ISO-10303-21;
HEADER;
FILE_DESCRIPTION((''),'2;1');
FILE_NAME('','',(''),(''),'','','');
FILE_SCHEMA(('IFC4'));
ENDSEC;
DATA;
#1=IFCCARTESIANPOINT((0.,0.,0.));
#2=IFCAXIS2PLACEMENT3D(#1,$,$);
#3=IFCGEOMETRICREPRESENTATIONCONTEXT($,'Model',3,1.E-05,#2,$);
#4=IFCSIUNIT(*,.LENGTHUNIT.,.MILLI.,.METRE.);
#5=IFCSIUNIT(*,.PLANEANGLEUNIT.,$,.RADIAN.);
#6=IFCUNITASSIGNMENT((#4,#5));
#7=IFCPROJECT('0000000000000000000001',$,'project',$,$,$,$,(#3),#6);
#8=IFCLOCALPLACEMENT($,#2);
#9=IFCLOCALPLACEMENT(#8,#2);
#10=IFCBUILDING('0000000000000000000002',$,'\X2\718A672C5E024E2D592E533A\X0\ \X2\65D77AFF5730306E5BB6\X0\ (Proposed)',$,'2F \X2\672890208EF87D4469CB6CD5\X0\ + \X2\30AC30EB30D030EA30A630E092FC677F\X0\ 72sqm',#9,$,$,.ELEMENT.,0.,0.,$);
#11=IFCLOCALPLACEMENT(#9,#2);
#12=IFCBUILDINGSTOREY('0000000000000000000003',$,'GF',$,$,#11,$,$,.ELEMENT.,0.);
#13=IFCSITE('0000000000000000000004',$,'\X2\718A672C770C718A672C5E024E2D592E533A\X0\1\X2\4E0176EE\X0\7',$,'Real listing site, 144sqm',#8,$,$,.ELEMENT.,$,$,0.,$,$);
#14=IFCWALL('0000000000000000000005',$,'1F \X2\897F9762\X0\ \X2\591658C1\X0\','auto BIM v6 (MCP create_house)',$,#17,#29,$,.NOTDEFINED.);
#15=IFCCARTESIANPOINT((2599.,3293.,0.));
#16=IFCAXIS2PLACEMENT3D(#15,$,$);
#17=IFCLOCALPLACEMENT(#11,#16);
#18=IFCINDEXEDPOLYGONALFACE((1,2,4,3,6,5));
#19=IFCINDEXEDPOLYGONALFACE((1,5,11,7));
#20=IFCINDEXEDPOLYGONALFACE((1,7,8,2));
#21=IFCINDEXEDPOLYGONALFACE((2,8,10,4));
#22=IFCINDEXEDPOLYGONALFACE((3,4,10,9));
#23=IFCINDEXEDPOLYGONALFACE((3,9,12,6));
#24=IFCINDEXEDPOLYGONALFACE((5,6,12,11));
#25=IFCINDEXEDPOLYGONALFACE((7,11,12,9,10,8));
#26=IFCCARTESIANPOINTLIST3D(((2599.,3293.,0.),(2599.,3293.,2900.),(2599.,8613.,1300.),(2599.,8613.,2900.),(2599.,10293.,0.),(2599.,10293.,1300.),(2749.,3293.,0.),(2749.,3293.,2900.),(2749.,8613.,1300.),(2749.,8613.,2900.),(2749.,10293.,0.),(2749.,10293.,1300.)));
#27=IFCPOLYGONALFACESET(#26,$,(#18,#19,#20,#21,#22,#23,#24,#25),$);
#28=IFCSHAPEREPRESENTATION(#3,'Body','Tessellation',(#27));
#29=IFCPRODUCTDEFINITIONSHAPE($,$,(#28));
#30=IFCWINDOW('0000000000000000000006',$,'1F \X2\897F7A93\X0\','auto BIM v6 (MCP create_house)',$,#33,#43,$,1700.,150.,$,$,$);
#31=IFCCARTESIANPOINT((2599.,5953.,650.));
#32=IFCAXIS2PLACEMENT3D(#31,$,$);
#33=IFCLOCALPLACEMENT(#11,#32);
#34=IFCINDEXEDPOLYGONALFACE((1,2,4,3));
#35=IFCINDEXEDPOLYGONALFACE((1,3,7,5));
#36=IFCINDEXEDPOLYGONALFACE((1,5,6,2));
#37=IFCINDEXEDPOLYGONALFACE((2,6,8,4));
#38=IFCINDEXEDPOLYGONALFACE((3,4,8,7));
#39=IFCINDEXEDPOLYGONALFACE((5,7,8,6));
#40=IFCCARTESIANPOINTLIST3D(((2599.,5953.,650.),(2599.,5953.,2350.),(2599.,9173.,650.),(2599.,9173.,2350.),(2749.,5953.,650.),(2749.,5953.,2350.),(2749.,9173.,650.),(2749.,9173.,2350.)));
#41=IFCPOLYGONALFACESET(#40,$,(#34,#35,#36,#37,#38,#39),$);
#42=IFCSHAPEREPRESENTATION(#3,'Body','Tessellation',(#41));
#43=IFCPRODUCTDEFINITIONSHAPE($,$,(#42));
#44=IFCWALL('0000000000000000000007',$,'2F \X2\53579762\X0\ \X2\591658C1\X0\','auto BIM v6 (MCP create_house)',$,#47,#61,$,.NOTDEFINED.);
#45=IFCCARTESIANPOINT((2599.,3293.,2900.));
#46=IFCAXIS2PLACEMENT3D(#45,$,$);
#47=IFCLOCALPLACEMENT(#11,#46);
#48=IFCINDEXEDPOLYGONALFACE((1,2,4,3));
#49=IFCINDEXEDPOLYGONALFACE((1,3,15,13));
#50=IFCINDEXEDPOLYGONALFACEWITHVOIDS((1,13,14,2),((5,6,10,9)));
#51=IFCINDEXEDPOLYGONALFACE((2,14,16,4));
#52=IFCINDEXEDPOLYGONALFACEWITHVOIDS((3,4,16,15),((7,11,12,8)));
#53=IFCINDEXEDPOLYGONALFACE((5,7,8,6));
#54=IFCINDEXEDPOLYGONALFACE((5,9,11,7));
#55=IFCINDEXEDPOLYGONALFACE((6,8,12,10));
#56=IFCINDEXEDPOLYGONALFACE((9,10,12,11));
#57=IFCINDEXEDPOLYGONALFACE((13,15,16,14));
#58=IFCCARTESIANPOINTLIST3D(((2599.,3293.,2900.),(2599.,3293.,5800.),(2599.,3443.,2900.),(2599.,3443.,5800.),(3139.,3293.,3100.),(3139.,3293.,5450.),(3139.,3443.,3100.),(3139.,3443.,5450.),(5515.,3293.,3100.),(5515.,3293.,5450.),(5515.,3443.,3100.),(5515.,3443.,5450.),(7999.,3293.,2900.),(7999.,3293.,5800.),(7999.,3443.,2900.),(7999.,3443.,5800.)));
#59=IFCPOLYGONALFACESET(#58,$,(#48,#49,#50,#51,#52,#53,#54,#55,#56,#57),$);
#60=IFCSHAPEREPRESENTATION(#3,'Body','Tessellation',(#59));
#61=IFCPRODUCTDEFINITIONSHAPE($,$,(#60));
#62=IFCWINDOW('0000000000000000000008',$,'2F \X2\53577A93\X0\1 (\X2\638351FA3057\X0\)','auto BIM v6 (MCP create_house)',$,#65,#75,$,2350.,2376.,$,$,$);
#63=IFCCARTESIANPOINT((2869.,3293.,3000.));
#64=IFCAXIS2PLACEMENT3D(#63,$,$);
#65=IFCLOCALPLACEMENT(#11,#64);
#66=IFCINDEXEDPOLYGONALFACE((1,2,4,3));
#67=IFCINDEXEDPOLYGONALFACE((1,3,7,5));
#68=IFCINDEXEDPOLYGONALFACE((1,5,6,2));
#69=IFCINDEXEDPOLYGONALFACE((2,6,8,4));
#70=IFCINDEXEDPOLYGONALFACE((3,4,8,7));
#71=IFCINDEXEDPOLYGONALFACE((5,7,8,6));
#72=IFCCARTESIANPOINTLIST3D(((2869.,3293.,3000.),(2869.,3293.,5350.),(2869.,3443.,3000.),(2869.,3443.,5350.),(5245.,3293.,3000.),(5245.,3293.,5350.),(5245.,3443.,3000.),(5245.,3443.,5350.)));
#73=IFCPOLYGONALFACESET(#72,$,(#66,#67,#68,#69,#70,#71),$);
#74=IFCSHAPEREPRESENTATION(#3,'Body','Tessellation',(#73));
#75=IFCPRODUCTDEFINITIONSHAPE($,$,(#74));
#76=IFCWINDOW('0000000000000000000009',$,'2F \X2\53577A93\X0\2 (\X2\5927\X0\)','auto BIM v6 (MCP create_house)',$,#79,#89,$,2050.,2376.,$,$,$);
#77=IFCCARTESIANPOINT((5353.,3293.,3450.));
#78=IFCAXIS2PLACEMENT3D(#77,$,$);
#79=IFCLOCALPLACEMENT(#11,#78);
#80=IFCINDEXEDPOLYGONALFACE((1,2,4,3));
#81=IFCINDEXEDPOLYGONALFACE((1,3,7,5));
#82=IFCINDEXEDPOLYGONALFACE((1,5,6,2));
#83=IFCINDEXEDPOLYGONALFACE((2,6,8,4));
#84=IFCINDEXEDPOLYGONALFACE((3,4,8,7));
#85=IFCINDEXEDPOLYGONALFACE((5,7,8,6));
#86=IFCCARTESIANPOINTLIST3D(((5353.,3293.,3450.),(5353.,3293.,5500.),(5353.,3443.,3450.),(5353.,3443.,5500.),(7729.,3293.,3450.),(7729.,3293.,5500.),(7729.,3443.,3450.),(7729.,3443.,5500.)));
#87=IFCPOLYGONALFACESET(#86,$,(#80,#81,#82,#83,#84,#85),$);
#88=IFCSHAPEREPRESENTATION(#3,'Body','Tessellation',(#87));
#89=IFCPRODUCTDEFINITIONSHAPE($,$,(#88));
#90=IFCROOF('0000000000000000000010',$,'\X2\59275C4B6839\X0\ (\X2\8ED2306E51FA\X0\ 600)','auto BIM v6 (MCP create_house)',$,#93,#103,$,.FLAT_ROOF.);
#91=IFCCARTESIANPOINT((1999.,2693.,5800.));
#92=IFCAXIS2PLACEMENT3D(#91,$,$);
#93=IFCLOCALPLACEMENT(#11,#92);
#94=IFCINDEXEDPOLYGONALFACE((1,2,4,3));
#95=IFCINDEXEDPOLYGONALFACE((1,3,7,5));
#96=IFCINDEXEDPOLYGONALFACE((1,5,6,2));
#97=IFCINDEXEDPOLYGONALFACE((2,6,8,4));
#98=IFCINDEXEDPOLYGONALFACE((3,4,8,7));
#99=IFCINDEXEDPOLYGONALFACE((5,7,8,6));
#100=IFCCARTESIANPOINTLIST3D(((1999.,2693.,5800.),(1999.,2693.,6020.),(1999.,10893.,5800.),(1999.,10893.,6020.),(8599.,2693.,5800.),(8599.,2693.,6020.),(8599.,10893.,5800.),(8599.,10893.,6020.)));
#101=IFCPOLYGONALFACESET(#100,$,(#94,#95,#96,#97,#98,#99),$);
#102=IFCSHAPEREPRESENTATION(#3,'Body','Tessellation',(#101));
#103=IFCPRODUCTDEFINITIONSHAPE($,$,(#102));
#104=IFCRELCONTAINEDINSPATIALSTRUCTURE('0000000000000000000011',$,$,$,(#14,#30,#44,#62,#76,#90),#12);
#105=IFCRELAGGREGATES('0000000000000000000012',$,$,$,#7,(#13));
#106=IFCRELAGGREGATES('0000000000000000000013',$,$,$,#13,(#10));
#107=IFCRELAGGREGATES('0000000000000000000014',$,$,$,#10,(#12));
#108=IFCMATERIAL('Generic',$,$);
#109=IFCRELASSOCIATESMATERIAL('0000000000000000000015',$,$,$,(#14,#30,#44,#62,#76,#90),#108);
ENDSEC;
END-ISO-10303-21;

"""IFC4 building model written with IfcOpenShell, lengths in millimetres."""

from ifc_helpers import new_model, si_unit, frame, frame_2d, origin, place, context, project, spatial, rectangle, extrude, material, element, fill, save


model = new_model("IFC4")

# Units and contexts
model_context = context("Model", 3, precision=1e-05, world=origin())
ifc_project = project(units=[si_unit("LENGTHUNIT", "METRE", prefix="MILLI"), si_unit("PLANEANGLEUNIT", "RADIAN")], contexts=[model_context])

# Site, building, storey
site_placement = place(None, origin())
site = spatial("IfcSite", under=ifc_project, at=site_placement, Name="熊本県熊本市中央区1丁目7", ObjectType="Real listing site, 144sqm", CompositionType="ELEMENT", RefElevation=0.0)
building_placement = place(site_placement, origin())
building = spatial("IfcBuilding", under=site, at=building_placement, Name="熊本市中央区 旗竿地の家 (Proposed)", ObjectType="2F 木造軸組構法 + ガルバリウム鋼板 72sqm", CompositionType="ELEMENT", ElevationOfRefHeight=0.0, ElevationOfTerrain=0.0)
storey_placement = place(building_placement, origin())
storey = spatial("IfcBuildingStorey", under=building, at=storey_placement, Name="GF", CompositionType="ELEMENT", Elevation=0.0)

# Shared definitions
ifc_material = material(Name="Generic")

# Wall, opening, window
wall_1_placement = place(storey_placement, frame((2599.0, 3293.0, 0.0)))
wall_1 = element("IfcWall", 1, at=wall_1_placement, inside=storey, material=ifc_material, Name="1F 西面 外壁", Description="auto BIM v6 (MCP create_house)", PredefinedType="NOTDEFINED", context=model_context, shape_type="SweptSolid", body=[
    extrude(rectangle(XDim=150.0, YDim=7000.0, at=frame_2d((75.0, 3500.0))), frame((2599.0, 3293.0, 0.0)), (0.0, 0.0, 1.0), 2900.0),
])
opening_1_placement = place(storey_placement, frame((2599.0, 5953.0, 650.0)))
opening_1 = element("IfcOpeningElement", 2, at=opening_1_placement, cuts=wall_1, PredefinedType="NOTDEFINED", context=model_context, shape_type="SweptSolid", body=[
    extrude(rectangle(XDim=150.0, YDim=3220.0, at=frame_2d((75.0, 1610.0))), frame((2599.0, 5953.0, 650.0)), (0.0, 0.0, 1.0), 1700.0),
])
window_1_placement = place(storey_placement, frame((2599.0, 5953.0, 650.0)))
window_1 = element("IfcWindow", 3, at=window_1_placement, inside=storey, material=ifc_material, Name="1F 西窓", Description="auto BIM v6 (MCP create_house)", OverallHeight=1700.0, OverallWidth=150.0, context=model_context, shape_type="SweptSolid", body=[
    extrude(rectangle(XDim=150.0, YDim=3220.0, at=frame_2d((75.0, 1610.0))), frame((2599.0, 5953.0, 650.0)), (0.0, 0.0, 1.0), 1700.0),
])
fill(opening_1, window_1)

# Wall, openings, windows
wall_2_placement = place(storey_placement, frame((2599.0, 3293.0, 2900.0)))
wall_2 = element("IfcWall", 4, at=wall_2_placement, inside=storey, material=ifc_material, Name="2F 南面 外壁", Description="auto BIM v6 (MCP create_house)", PredefinedType="NOTDEFINED", context=model_context, shape_type="SweptSolid", body=[
    extrude(rectangle(XDim=5400.0, YDim=150.0, at=frame_2d((2700.0, 75.0))), frame((2599.0, 3293.0, 2900.0)), (0.0, 0.0, 1.0), 2900.0),
])
opening_2_placement = place(storey_placement, frame((2869.0, 3293.0, 3000.0)))
opening_2 = element("IfcOpeningElement", 5, at=opening_2_placement, cuts=wall_2, PredefinedType="NOTDEFINED", context=model_context, shape_type="SweptSolid", body=[
    extrude(rectangle(XDim=2376.0, YDim=150.0, at=frame_2d((1188.0, 75.0))), frame((2869.0, 3293.0, 3000.0)), (0.0, 0.0, 1.0), 2350.0),
])
opening_3_placement = place(storey_placement, frame((5353.0, 3293.0, 3450.0)))
opening_3 = element("IfcOpeningElement", 6, at=opening_3_placement, cuts=wall_2, PredefinedType="NOTDEFINED", context=model_context, shape_type="SweptSolid", body=[
    extrude(rectangle(XDim=2376.0, YDim=150.0, at=frame_2d((1188.0, 75.0))), frame((5353.0, 3293.0, 3450.0)), (0.0, 0.0, 1.0), 2050.0),
])
window_2_placement = place(storey_placement, frame((2869.0, 3293.0, 3000.0)))
window_2 = element("IfcWindow", 7, at=window_2_placement, inside=storey, material=ifc_material, Name="2F 南窓1 (掃出し)", Description="auto BIM v6 (MCP create_house)", OverallHeight=2350.0, OverallWidth=2376.0, context=model_context, shape_type="SweptSolid", body=[
    extrude(rectangle(XDim=2376.0, YDim=150.0, at=frame_2d((1188.0, 75.0))), frame((2869.0, 3293.0, 3000.0)), (0.0, 0.0, 1.0), 2350.0),
])
fill(opening_2, window_2)
window_3_placement = place(storey_placement, frame((5353.0, 3293.0, 3450.0)))
window_3 = element("IfcWindow", 8, at=window_3_placement, inside=storey, material=ifc_material, Name="2F 南窓2 (大)", Description="auto BIM v6 (MCP create_house)", OverallHeight=2050.0, OverallWidth=2376.0, context=model_context, shape_type="SweptSolid", body=[
    extrude(rectangle(XDim=2376.0, YDim=150.0, at=frame_2d((1188.0, 75.0))), frame((5353.0, 3293.0, 3450.0)), (0.0, 0.0, 1.0), 2050.0),
])
fill(opening_3, window_3)

# Roof
roof_placement = place(storey_placement, frame((1999.0, 2693.0, 5800.0)))
element("IfcRoof", 9, at=roof_placement, inside=storey, material=ifc_material, Name="大屋根 (軒の出 600)", Description="auto BIM v6 (MCP create_house)", PredefinedType="FLAT_ROOF", context=model_context, shape_type="SweptSolid", body=[
    extrude(rectangle(XDim=6600.0, YDim=8200.0, at=frame_2d((3300.0, 4100.0))), frame((1999.0, 2693.0, 5800.0)), (0.0, 0.0, 1.0), 220.0),
])

save(model, "model.ifc")
